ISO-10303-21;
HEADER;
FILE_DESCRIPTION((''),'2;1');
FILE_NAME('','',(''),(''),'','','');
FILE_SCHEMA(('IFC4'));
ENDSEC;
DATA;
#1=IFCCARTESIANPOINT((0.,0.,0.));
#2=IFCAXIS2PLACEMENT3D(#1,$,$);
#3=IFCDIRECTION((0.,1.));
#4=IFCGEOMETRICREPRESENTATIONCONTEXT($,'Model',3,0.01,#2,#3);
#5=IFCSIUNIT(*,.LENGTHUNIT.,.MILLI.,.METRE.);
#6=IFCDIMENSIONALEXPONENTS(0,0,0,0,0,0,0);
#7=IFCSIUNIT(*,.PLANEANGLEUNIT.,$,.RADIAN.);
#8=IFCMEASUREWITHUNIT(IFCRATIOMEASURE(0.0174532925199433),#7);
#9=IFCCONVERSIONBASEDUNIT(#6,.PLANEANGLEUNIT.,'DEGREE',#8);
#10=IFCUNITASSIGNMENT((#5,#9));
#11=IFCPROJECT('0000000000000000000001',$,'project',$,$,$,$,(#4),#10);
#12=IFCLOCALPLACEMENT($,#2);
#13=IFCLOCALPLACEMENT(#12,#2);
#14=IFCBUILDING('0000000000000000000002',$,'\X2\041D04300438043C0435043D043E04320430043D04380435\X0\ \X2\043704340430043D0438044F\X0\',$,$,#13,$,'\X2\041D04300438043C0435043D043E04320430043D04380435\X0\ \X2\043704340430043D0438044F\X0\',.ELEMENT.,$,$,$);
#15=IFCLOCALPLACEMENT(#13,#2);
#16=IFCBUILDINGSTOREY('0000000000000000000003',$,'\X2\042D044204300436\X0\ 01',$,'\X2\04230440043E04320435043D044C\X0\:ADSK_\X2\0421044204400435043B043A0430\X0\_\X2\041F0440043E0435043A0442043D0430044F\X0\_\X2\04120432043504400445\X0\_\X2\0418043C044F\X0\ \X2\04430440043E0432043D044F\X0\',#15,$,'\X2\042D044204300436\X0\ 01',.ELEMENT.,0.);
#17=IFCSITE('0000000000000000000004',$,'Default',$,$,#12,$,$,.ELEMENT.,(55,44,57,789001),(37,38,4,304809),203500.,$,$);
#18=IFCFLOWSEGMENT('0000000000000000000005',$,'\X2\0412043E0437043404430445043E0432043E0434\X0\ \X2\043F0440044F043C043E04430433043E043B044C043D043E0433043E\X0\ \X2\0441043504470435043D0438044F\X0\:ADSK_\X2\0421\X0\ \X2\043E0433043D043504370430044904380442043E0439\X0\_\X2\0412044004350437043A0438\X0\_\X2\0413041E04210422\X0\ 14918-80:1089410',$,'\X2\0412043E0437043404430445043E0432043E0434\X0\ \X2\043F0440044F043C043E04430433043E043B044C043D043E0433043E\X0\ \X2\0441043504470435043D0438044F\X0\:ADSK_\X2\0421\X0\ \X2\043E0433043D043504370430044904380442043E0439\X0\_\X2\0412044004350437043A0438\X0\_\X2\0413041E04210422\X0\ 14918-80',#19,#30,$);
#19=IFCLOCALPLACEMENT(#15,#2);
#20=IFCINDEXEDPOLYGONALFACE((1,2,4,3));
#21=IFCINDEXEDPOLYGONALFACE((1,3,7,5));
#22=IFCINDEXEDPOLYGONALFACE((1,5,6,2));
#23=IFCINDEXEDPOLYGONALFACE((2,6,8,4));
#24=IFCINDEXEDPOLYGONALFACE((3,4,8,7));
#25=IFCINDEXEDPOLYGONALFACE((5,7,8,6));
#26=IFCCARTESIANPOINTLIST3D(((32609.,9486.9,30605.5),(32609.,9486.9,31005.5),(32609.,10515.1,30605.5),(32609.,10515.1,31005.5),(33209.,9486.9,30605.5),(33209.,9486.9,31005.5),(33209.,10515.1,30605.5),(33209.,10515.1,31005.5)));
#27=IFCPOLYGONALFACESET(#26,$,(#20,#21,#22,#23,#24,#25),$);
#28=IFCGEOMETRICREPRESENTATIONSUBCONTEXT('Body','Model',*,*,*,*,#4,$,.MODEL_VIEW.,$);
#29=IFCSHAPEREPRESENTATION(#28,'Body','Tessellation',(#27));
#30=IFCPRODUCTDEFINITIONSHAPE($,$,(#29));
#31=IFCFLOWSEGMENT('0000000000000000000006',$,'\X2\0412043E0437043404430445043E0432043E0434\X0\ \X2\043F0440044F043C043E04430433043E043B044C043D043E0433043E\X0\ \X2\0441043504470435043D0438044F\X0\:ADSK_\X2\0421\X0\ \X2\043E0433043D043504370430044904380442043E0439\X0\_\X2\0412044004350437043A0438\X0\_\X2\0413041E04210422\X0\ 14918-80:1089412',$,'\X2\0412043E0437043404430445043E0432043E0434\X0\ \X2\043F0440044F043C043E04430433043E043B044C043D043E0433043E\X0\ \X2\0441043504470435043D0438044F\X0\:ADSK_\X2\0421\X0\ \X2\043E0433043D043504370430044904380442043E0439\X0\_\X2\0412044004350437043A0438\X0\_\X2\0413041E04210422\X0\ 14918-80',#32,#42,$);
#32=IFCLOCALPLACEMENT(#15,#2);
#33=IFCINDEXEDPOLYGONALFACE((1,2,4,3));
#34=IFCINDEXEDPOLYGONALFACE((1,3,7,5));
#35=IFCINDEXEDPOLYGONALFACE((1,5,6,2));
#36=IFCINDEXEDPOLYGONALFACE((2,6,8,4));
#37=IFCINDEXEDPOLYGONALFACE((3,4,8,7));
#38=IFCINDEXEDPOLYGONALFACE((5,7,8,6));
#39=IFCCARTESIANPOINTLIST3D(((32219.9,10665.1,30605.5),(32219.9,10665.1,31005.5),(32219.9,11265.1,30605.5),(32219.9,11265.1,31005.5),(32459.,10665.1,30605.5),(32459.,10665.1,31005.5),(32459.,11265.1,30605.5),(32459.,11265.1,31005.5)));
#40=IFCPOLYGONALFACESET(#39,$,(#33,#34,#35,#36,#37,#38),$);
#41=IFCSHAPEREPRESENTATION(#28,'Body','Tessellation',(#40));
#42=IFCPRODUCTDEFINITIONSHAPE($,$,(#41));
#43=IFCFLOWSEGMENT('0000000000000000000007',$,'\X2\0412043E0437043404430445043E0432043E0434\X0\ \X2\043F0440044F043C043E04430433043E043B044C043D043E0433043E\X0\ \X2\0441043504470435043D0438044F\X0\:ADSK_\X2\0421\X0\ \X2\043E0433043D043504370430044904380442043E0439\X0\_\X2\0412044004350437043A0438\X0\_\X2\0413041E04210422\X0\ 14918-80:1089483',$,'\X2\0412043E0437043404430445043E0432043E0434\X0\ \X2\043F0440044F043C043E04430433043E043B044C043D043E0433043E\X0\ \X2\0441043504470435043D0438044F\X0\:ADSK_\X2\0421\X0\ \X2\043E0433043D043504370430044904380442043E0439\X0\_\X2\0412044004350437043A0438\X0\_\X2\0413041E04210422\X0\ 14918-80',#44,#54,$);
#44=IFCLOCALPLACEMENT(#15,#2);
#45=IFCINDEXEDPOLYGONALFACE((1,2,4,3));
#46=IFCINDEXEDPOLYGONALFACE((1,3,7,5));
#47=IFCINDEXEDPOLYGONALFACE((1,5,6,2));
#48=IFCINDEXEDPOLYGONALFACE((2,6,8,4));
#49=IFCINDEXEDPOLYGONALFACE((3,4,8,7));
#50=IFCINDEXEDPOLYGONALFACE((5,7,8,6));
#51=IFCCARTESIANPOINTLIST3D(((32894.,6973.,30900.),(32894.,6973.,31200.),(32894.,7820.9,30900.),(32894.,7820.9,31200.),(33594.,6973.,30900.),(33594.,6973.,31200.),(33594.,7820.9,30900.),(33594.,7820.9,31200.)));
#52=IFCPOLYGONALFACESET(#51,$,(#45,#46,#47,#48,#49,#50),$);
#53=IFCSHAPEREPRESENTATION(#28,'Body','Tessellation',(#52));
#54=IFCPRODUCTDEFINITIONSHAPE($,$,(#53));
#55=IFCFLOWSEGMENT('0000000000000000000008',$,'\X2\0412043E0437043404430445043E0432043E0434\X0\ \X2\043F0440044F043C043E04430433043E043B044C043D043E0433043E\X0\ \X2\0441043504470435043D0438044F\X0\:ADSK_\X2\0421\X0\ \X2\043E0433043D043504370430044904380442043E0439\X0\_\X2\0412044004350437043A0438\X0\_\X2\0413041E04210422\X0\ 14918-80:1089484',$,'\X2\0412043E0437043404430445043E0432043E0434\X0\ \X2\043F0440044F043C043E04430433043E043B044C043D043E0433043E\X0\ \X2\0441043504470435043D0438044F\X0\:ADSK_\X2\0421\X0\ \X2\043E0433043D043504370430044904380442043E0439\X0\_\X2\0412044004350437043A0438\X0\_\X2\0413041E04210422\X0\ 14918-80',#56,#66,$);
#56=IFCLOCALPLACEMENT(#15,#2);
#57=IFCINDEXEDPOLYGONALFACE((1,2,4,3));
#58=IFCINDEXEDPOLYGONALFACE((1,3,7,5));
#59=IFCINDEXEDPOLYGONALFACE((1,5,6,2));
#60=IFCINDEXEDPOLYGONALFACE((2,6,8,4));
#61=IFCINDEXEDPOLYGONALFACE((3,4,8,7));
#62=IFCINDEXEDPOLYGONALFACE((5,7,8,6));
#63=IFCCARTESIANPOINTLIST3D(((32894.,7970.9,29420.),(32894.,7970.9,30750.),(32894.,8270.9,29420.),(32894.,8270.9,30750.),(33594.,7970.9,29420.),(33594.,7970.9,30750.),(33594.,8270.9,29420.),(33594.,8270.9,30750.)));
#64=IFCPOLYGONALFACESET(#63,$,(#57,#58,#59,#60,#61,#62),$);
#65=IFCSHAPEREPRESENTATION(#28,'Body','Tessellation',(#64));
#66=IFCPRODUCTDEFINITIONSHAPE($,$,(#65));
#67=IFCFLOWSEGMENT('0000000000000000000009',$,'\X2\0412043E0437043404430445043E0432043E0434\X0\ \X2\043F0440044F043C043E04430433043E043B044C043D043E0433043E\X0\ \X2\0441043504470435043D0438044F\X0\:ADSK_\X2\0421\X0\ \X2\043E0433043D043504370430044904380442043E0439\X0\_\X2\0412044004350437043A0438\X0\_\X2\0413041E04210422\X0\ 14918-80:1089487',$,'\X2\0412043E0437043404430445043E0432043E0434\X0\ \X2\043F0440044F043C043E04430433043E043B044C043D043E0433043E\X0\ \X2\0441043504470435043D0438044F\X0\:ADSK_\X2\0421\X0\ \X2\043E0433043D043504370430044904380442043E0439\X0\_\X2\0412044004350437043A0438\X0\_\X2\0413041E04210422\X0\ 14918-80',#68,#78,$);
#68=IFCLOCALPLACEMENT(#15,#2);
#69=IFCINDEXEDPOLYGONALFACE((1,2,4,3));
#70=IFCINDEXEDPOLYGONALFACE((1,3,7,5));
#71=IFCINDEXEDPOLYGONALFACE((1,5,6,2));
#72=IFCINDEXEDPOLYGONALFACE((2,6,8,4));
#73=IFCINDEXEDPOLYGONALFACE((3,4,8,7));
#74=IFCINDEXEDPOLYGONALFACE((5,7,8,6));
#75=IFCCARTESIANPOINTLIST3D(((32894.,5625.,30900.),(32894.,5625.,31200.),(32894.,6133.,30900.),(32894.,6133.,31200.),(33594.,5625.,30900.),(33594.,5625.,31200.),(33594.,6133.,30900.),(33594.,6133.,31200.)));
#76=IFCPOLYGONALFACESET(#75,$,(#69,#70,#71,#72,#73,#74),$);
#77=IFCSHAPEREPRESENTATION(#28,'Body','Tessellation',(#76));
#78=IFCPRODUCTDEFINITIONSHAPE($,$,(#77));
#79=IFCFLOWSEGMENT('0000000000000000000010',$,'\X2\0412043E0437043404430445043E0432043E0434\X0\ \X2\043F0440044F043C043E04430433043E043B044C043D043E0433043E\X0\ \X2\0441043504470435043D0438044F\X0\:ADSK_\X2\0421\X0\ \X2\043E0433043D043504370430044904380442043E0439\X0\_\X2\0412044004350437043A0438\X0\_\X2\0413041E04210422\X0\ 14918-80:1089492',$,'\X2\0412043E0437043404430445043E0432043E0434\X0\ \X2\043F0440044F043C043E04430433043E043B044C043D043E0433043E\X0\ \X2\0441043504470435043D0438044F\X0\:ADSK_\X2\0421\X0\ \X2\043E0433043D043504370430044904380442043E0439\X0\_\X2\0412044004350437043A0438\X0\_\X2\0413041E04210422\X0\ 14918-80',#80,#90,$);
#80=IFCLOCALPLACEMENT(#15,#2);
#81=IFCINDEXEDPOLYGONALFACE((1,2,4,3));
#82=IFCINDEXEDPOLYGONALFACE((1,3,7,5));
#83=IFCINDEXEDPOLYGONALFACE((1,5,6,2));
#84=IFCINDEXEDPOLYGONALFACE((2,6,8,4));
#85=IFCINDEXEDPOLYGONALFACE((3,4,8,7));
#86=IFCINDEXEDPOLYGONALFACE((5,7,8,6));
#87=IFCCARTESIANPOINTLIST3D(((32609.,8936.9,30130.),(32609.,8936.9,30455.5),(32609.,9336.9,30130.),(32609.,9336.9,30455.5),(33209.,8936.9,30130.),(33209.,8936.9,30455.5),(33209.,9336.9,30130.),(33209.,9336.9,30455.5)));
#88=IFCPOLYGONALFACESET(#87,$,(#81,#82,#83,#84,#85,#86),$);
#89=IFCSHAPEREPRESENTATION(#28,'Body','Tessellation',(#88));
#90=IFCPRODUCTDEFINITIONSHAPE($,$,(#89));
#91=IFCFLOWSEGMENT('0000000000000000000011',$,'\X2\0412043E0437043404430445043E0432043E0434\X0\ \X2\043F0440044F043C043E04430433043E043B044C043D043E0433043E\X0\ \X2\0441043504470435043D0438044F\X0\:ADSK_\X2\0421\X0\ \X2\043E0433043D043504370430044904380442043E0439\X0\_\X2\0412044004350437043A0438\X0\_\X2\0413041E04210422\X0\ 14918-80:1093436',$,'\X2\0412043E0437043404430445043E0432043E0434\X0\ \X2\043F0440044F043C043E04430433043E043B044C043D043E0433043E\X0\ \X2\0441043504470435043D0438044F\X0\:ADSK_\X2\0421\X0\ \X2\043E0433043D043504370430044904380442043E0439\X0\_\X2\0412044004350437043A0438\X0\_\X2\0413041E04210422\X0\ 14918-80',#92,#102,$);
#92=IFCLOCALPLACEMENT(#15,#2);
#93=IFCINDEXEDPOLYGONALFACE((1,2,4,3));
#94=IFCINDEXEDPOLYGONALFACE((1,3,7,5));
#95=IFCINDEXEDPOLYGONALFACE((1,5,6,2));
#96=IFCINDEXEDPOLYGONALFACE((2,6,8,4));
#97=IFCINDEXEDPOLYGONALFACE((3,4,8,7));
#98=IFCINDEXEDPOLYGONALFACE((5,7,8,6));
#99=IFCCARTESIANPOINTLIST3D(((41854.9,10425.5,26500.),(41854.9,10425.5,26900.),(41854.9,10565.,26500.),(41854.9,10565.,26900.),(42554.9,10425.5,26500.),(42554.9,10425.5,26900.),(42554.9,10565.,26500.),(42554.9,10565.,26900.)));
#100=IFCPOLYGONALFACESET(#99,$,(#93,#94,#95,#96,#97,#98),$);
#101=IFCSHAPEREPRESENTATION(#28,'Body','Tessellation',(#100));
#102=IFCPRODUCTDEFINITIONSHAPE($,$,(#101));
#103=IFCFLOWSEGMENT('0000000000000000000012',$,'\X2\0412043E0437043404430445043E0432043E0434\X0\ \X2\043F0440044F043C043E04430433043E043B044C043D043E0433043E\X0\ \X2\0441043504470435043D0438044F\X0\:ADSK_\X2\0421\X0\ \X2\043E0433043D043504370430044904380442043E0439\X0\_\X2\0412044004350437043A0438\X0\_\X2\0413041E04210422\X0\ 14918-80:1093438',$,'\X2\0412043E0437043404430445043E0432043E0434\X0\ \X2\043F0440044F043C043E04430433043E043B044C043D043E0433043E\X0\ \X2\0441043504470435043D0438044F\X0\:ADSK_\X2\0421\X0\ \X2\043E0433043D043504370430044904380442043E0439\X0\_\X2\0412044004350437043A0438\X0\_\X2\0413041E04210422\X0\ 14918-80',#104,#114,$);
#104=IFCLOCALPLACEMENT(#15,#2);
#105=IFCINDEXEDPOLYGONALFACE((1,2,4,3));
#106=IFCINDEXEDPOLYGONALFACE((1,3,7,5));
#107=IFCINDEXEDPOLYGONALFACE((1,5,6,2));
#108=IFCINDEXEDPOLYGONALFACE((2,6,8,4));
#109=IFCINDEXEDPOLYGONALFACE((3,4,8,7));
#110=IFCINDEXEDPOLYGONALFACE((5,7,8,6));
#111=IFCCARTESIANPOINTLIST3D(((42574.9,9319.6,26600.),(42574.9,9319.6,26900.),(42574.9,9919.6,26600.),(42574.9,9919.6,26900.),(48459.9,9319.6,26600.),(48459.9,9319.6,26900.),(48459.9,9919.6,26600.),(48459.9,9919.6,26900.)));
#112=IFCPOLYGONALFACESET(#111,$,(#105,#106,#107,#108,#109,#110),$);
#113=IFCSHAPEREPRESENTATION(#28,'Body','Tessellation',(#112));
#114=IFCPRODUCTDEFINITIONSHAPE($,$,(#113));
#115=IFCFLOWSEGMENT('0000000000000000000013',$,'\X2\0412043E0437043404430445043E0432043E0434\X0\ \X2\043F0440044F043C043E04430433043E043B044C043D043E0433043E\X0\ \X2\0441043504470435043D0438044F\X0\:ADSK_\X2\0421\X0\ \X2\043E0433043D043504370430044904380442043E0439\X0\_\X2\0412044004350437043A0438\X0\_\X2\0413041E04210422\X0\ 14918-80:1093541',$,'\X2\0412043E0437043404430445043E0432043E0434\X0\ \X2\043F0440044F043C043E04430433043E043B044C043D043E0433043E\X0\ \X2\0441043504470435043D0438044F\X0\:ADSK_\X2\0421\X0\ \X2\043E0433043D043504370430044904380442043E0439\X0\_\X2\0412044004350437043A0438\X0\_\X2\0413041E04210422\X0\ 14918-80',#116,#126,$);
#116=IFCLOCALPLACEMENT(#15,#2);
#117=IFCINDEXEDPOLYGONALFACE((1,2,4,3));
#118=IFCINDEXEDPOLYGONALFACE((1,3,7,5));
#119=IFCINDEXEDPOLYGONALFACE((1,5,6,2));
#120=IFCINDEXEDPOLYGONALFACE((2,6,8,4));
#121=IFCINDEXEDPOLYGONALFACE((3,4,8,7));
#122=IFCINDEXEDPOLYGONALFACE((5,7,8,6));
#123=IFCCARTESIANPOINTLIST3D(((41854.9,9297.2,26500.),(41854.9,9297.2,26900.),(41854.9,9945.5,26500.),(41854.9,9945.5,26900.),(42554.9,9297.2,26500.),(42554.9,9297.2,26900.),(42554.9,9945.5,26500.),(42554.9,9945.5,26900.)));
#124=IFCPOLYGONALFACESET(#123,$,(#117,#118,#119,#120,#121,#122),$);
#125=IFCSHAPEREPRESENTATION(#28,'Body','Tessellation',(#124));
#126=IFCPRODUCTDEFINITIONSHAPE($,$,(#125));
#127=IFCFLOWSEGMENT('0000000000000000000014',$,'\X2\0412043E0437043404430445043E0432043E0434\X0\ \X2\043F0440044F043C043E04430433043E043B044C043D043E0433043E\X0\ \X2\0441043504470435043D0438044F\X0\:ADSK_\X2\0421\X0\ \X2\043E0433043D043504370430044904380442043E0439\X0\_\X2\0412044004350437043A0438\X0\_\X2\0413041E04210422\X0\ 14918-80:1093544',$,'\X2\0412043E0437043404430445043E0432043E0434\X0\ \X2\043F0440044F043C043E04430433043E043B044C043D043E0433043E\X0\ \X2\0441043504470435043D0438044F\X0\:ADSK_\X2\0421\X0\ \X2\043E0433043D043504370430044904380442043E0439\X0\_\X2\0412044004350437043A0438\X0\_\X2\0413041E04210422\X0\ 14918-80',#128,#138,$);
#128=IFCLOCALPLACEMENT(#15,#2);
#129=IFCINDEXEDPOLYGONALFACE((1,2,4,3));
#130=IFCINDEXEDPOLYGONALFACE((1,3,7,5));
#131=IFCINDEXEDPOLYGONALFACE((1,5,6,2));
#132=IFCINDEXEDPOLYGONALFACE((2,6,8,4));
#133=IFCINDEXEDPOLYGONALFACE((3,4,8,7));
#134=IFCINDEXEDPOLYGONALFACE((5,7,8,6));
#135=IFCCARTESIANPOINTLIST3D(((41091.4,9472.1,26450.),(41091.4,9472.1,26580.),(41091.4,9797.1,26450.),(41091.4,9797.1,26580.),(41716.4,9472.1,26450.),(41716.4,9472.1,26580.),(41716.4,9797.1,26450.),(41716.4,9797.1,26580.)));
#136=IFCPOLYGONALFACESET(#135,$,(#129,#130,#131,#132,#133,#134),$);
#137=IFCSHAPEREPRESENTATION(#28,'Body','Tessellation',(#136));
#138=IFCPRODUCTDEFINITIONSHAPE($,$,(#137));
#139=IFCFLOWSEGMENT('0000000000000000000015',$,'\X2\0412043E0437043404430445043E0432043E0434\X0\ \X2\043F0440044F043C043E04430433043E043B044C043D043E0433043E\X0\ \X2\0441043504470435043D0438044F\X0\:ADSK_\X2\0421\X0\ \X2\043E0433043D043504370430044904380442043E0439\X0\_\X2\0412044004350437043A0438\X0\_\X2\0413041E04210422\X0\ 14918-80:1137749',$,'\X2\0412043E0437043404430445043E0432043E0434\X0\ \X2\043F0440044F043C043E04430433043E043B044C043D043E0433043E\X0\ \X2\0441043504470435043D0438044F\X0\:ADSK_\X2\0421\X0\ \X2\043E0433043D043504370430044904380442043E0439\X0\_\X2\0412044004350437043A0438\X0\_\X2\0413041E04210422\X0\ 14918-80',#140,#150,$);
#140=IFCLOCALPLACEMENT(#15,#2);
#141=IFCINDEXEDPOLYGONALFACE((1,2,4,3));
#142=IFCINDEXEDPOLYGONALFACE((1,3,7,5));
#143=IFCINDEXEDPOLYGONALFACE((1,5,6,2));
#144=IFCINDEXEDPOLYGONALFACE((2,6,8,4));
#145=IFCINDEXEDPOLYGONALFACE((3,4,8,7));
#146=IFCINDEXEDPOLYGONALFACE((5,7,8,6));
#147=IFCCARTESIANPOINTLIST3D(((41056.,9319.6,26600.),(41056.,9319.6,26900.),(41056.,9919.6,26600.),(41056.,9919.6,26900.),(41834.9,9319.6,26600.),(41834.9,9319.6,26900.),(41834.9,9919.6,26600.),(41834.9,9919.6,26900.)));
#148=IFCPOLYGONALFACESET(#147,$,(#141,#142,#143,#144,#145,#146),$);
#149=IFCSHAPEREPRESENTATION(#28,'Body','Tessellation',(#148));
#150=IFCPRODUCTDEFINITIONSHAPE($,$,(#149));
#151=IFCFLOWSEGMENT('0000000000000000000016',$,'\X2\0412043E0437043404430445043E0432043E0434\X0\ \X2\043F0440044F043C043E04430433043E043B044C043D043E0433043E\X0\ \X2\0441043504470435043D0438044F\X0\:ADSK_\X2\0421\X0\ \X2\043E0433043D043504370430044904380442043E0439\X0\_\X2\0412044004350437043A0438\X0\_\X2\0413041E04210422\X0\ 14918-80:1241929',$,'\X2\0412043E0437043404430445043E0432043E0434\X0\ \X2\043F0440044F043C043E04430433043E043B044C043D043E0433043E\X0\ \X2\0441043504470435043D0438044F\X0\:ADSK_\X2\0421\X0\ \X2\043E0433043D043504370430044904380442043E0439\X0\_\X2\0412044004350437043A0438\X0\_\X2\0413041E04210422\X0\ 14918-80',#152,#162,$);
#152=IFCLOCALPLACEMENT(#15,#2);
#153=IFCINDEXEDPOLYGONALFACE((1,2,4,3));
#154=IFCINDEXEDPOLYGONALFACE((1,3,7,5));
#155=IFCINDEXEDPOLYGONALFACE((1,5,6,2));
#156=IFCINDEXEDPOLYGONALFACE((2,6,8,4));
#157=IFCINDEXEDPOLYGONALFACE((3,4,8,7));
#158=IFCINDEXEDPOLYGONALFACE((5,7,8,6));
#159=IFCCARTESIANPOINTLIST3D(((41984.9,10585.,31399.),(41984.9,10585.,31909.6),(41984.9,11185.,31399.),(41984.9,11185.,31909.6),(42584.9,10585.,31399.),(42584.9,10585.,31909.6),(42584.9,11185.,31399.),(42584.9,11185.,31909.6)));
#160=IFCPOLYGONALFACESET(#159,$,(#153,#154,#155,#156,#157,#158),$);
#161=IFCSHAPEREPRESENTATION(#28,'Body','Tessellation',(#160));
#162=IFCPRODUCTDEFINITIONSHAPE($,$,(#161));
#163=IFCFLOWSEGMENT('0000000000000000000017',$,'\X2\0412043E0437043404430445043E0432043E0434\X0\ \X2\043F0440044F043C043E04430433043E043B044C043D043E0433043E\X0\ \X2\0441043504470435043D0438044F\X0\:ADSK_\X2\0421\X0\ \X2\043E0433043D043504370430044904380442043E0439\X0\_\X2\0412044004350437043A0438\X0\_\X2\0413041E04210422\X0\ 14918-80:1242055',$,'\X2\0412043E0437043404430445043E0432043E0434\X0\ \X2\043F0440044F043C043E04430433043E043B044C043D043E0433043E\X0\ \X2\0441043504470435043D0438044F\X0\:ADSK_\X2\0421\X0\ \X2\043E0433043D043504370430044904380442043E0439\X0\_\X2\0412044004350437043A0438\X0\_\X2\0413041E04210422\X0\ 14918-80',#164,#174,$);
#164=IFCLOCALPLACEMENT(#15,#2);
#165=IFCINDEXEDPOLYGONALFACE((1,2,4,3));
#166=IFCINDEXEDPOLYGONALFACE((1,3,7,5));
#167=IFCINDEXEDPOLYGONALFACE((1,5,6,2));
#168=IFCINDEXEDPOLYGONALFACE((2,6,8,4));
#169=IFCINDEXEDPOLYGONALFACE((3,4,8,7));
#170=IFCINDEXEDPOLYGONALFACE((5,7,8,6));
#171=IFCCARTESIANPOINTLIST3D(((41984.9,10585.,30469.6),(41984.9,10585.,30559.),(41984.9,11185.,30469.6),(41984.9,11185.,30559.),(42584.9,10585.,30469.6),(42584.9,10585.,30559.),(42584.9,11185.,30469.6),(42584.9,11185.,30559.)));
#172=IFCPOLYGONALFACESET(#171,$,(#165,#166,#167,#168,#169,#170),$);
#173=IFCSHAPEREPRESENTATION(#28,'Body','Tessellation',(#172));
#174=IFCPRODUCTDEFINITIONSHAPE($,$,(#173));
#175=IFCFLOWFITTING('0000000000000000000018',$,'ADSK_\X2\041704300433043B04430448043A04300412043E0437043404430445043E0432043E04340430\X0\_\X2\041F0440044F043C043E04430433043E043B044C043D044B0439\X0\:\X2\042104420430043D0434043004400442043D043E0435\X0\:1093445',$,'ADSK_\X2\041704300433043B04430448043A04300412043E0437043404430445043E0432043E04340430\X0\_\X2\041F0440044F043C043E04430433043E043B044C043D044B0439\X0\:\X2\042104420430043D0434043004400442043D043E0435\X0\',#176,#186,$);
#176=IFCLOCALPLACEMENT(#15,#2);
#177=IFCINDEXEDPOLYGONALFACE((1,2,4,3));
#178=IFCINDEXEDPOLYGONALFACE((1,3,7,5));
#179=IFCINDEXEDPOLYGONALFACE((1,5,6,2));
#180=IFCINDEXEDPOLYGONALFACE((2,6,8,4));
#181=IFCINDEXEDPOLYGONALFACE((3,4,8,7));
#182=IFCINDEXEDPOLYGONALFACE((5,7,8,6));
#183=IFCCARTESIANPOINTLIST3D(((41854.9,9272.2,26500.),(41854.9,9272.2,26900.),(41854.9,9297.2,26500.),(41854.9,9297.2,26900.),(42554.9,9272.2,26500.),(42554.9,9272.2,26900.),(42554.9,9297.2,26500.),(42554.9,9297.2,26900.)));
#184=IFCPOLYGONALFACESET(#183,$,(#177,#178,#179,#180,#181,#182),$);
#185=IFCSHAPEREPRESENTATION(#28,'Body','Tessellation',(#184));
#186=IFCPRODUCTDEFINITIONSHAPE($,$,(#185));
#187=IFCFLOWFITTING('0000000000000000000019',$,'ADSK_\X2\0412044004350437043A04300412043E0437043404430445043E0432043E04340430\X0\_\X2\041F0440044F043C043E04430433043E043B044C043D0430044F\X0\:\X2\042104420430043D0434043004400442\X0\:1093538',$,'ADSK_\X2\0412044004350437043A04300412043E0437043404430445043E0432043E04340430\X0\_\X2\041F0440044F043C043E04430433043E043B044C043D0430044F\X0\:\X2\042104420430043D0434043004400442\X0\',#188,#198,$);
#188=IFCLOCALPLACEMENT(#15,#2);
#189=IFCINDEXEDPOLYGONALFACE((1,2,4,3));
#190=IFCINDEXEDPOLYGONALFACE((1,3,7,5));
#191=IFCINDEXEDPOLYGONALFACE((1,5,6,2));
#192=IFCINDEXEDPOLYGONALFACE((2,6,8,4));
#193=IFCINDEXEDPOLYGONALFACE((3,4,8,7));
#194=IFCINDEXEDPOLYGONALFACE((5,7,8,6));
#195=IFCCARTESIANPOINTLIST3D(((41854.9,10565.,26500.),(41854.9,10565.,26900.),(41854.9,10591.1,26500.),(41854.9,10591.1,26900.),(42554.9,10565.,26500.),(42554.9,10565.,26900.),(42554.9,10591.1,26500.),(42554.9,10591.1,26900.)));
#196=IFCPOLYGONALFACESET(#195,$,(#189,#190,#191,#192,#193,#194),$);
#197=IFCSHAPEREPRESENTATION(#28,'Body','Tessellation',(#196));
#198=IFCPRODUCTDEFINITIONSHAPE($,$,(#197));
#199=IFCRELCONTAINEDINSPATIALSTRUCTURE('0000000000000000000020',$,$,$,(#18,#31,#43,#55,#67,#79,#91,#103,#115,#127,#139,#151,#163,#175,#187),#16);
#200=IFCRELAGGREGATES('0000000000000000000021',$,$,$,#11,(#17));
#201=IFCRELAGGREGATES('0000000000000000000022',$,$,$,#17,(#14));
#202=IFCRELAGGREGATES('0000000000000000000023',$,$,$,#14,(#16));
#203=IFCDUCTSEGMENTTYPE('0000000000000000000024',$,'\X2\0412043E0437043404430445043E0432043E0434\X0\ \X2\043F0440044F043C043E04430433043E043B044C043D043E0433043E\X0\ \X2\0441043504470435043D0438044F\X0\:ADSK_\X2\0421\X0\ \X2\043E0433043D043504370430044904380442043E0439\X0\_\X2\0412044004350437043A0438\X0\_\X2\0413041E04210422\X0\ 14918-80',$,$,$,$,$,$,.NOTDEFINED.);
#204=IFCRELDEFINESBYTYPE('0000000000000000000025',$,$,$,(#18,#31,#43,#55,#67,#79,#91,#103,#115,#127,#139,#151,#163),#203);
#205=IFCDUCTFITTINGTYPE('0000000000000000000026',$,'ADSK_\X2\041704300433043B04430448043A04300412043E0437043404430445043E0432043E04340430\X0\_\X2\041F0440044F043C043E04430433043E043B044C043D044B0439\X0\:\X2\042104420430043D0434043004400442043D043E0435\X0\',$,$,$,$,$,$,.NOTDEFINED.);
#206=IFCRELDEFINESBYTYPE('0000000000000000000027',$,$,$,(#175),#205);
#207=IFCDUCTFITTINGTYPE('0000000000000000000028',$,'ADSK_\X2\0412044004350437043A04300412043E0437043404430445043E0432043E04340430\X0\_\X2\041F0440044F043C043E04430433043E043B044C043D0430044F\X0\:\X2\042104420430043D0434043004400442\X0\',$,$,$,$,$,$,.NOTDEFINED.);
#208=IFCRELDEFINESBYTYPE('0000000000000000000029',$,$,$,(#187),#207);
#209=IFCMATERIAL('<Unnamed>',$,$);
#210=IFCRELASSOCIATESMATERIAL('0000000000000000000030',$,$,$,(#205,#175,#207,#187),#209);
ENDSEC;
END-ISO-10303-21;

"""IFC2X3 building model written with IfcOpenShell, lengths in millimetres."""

from ifc_helpers import new_model, entity, si_unit, converted_unit, direction, frame, origin, origin_2d_with_axis, place, context, subcontext, project, spatial, rectangle, extrude, source, transform, mapped, material, type_object, type_shapes, element, save


model = new_model("IFC2X3")

# Units and contexts
model_context = context("Model", 3, precision=0.01, world=origin(), true_north=direction((0.0, 1.0)))
body_context = subcontext(model_context, "Body", "Model", "MODEL_VIEW")
ifc_project = project(units=[si_unit("LENGTHUNIT", "METRE", prefix="MILLI"), converted_unit("PLANEANGLEUNIT", "DEGREE", entity("IfcRatioMeasure", 0.0174532925199433), si_unit("PLANEANGLEUNIT", "RADIAN"), dimensions=[0, 0, 0, 0, 0, 0, 0])], contexts=[model_context])

# Site, building, storey
site_placement = place(None, origin())
site = spatial("IfcSite", under=ifc_project, at=site_placement, Name="Default", CompositionType="ELEMENT", RefLatitude=(55, 44, 57, 789001), RefLongitude=(37, 38, 4, 304809), RefElevation=203500.0)
building_placement = place(site_placement, origin())
building = spatial("IfcBuilding", under=site, at=building_placement, Name="Наименование здания", LongName="Наименование здания", CompositionType="ELEMENT")
storey_placement = place(building_placement, origin())
storey = spatial("IfcBuildingStorey", under=building, at=storey_placement, Name="Этаж 01", ObjectType="Уровень:ADSK_Стрелка_Проектная_Вверх_Имя уровня", LongName="Этаж 01", CompositionType="ELEMENT", Elevation=0.0)

# Flow segments
duct_segment_type = type_object("IfcDuctSegmentType", Name="Воздуховод прямоугольного сечения:ADSK_С огнезащитой_Врезки_ГОСТ 14918-80", PredefinedType="NOTDEFINED")
flow_segment_1_placement = place(storey_placement, frame((32609.0, 9486.9, 30605.5)))
element("IfcFlowSegment", 1, at=flow_segment_1_placement, inside=storey, type_object=duct_segment_type, Name="Воздуховод прямоугольного сечения:ADSK_С огнезащитой_Врезки_ГОСТ 14918-80:1089410", ObjectType="Воздуховод прямоугольного сечения:ADSK_С огнезащитой_Врезки_ГОСТ 14918-80", context=body_context, shape_type="SweptSolid", body=[
    extrude(rectangle(XDim=1028.2, YDim=600.0, at=origin_2d_with_axis()), frame((300.0, 514.1, 0.0), z_axis=(0.0, 0.0, 1.0), x_axis=(0.0, 1.0, 0.0)), (0.0, 0.0, 1.0), 400.0),
])
flow_segment_2_placement = place(storey_placement, frame((32219.9, 10665.1, 30605.5)))
element("IfcFlowSegment", 2, at=flow_segment_2_placement, inside=storey, type_object=duct_segment_type, Name="Воздуховод прямоугольного сечения:ADSK_С огнезащитой_Врезки_ГОСТ 14918-80:1089412", ObjectType="Воздуховод прямоугольного сечения:ADSK_С огнезащитой_Врезки_ГОСТ 14918-80", context=body_context, shape_type="SweptSolid", body=[
    extrude(rectangle(XDim=239.1, YDim=600.0, at=origin_2d_with_axis()), frame((119.6, 300.0, 0.0)), (0.0, 0.0, 1.0), 400.0),
])
flow_segment_3_placement = place(storey_placement, frame((32894.0, 6973.0, 30900.0)))
element("IfcFlowSegment", 3, at=flow_segment_3_placement, inside=storey, type_object=duct_segment_type, Name="Воздуховод прямоугольного сечения:ADSK_С огнезащитой_Врезки_ГОСТ 14918-80:1089483", ObjectType="Воздуховод прямоугольного сечения:ADSK_С огнезащитой_Врезки_ГОСТ 14918-80", context=body_context, shape_type="SweptSolid", body=[
    extrude(rectangle(XDim=848.0, YDim=700.0, at=origin_2d_with_axis()), frame((350.0, 424.0, 0.0), z_axis=(0.0, 0.0, 1.0), x_axis=(0.0, -1.0, 0.0)), (0.0, 0.0, 1.0), 300.0),
])
flow_segment_4_placement = place(storey_placement, frame((32894.0, 7970.9, 29420.0)))
element("IfcFlowSegment", 4, at=flow_segment_4_placement, inside=storey, type_object=duct_segment_type, Name="Воздуховод прямоугольного сечения:ADSK_С огнезащитой_Врезки_ГОСТ 14918-80:1089484", ObjectType="Воздуховод прямоугольного сечения:ADSK_С огнезащитой_Врезки_ГОСТ 14918-80", context=body_context, shape_type="SweptSolid", body=[
    extrude(rectangle(XDim=300.0, YDim=700.0, at=origin_2d_with_axis()), frame((350.0, 150.0, 0.0), z_axis=(0.0, 0.0, 1.0), x_axis=(0.0, 1.0, 0.0)), (0.0, 0.0, 1.0), 1330.0),
])
flow_segment_5_placement = place(storey_placement, frame((32894.0, 5625.0, 30900.0)))
element("IfcFlowSegment", 5, at=flow_segment_5_placement, inside=storey, type_object=duct_segment_type, Name="Воздуховод прямоугольного сечения:ADSK_С огнезащитой_Врезки_ГОСТ 14918-80:1089487", ObjectType="Воздуховод прямоугольного сечения:ADSK_С огнезащитой_Врезки_ГОСТ 14918-80", context=body_context, shape_type="SweptSolid", body=[
    extrude(rectangle(XDim=508.0, YDim=700.0, at=origin_2d_with_axis()), frame((350.0, 254.0, 0.0), z_axis=(0.0, 0.0, 1.0), x_axis=(0.0, -1.0, 0.0)), (0.0, 0.0, 1.0), 300.0),
])
flow_segment_6_placement = place(storey_placement, frame((32609.0, 8936.9, 30130.0)))
element("IfcFlowSegment", 6, at=flow_segment_6_placement, inside=storey, type_object=duct_segment_type, Name="Воздуховод прямоугольного сечения:ADSK_С огнезащитой_Врезки_ГОСТ 14918-80:1089492", ObjectType="Воздуховод прямоугольного сечения:ADSK_С огнезащитой_Врезки_ГОСТ 14918-80", context=body_context, shape_type="SweptSolid", body=[
    extrude(rectangle(XDim=600.0, YDim=400.0, at=origin_2d_with_axis()), frame((300.0, 200.0, 0.0)), (0.0, 0.0, 1.0), 325.5),
])
flow_segment_7_placement = place(storey_placement, frame((41854.9, 10425.5, 26500.0)))
element("IfcFlowSegment", 7, at=flow_segment_7_placement, inside=storey, type_object=duct_segment_type, Name="Воздуховод прямоугольного сечения:ADSK_С огнезащитой_Врезки_ГОСТ 14918-80:1093436", ObjectType="Воздуховод прямоугольного сечения:ADSK_С огнезащитой_Врезки_ГОСТ 14918-80", context=body_context, shape_type="SweptSolid", body=[
    extrude(rectangle(XDim=139.5, YDim=700.0, at=origin_2d_with_axis()), frame((350.0, 69.7, 0.0), z_axis=(0.0, 0.0, 1.0), x_axis=(0.0, 1.0, 0.0)), (0.0, 0.0, 1.0), 400.0),
])
flow_segment_8_placement = place(storey_placement, frame((42574.9, 9319.6, 26600.0)))
element("IfcFlowSegment", 8, at=flow_segment_8_placement, inside=storey, type_object=duct_segment_type, Name="Воздуховод прямоугольного сечения:ADSK_С огнезащитой_Врезки_ГОСТ 14918-80:1093438", ObjectType="Воздуховод прямоугольного сечения:ADSK_С огнезащитой_Врезки_ГОСТ 14918-80", context=body_context, shape_type="SweptSolid", body=[
    extrude(rectangle(XDim=5885.0, YDim=600.0, at=origin_2d_with_axis()), frame((2942.5, 300.0, 0.0), z_axis=(0.0, 0.0, 1.0), x_axis=(-1.0, 0.0, 0.0)), (0.0, 0.0, 1.0), 300.0),
])
flow_segment_9_placement = place(storey_placement, frame((41854.9, 9297.2, 26500.0)))
element("IfcFlowSegment", 9, at=flow_segment_9_placement, inside=storey, type_object=duct_segment_type, Name="Воздуховод прямоугольного сечения:ADSK_С огнезащитой_Врезки_ГОСТ 14918-80:1093541", ObjectType="Воздуховод прямоугольного сечения:ADSK_С огнезащитой_Врезки_ГОСТ 14918-80", context=body_context, shape_type="SweptSolid", body=[
    extrude(rectangle(XDim=648.3, YDim=700.0, at=origin_2d_with_axis()), frame((350.0, 324.1, 0.0), z_axis=(0.0, 0.0, 1.0), x_axis=(0.0, 1.0, 0.0)), (0.0, 0.0, 1.0), 400.0),
])
flow_segment_10_placement = place(storey_placement, frame((41091.4, 9472.1, 26450.0)))
element("IfcFlowSegment", 10, at=flow_segment_10_placement, inside=storey, type_object=duct_segment_type, Name="Воздуховод прямоугольного сечения:ADSK_С огнезащитой_Врезки_ГОСТ 14918-80:1093544", ObjectType="Воздуховод прямоугольного сечения:ADSK_С огнезащитой_Врезки_ГОСТ 14918-80", context=body_context, shape_type="SweptSolid", body=[
    extrude(rectangle(XDim=625.0, YDim=325.0, at=origin_2d_with_axis()), frame((312.5, 162.5, 0.0)), (0.0, 0.0, 1.0), 130.0),
])
flow_segment_11_placement = place(storey_placement, frame((41056.0, 9319.6, 26600.0)))
element("IfcFlowSegment", 11, at=flow_segment_11_placement, inside=storey, type_object=duct_segment_type, Name="Воздуховод прямоугольного сечения:ADSK_С огнезащитой_Врезки_ГОСТ 14918-80:1137749", ObjectType="Воздуховод прямоугольного сечения:ADSK_С огнезащитой_Врезки_ГОСТ 14918-80", context=body_context, shape_type="SweptSolid", body=[
    extrude(rectangle(XDim=778.9, YDim=600.0, at=origin_2d_with_axis()), frame((389.4, 300.0, 0.0)), (0.0, 0.0, 1.0), 300.0),
])
flow_segment_12_placement = place(storey_placement, frame((41984.9, 10585.0, 31399.0)))
element("IfcFlowSegment", 12, at=flow_segment_12_placement, inside=storey, type_object=duct_segment_type, Name="Воздуховод прямоугольного сечения:ADSK_С огнезащитой_Врезки_ГОСТ 14918-80:1241929", ObjectType="Воздуховод прямоугольного сечения:ADSK_С огнезащитой_Врезки_ГОСТ 14918-80", context=body_context, shape_type="SweptSolid", body=[
    extrude(rectangle(XDim=600.0, YDim=600.0, at=origin_2d_with_axis()), frame((300.0, 300.0, 0.0)), (0.0, 0.0, 1.0), 510.6),
])
flow_segment_13_placement = place(storey_placement, frame((41984.9, 10585.0, 30469.6)))
element("IfcFlowSegment", 13, at=flow_segment_13_placement, inside=storey, type_object=duct_segment_type, Name="Воздуховод прямоугольного сечения:ADSK_С огнезащитой_Врезки_ГОСТ 14918-80:1242055", ObjectType="Воздуховод прямоугольного сечения:ADSK_С огнезащитой_Врезки_ГОСТ 14918-80", context=body_context, shape_type="SweptSolid", body=[
    extrude(rectangle(XDim=600.0, YDim=600.0, at=origin_2d_with_axis()), frame((300.0, 300.0, 0.0)), (0.0, 0.0, 1.0), 89.4),
])

# Flow fittings
ifc_material_1 = material(Name="<Unnamed>")
duct_fitting_type_1 = type_object("IfcDuctFittingType", Name="ADSK_ЗаглушкаВоздуховода_Прямоугольный:Стандартное", PredefinedType="NOTDEFINED", material=ifc_material_1)
shared_shape_1 = source(origin(), body_context, "Body", "SweptSolid", [
    extrude(rectangle(XDim=25.0, YDim=700.0, at=origin_2d_with_axis()), frame((12.5, 0.0, -200.0)), (0.0, 0.0, 1.0), 400.0),
])
type_shapes(duct_fitting_type_1, [shared_shape_1])
flow_fitting_1_placement = place(storey_placement, frame((42204.9, 9297.2, 26700.0), z_axis=(0.0, 0.0, 1.0), x_axis=(0.0, -1.0, 0.0)))
element("IfcFlowFitting", 14, at=flow_fitting_1_placement, inside=storey, type_object=duct_fitting_type_1, material=ifc_material_1, Name="ADSK_ЗаглушкаВоздуховода_Прямоугольный:Стандартное:1093445", ObjectType="ADSK_ЗаглушкаВоздуховода_Прямоугольный:Стандартное", context=body_context, shape_type="MappedRepresentation", body=[
    mapped(shared_shape_1, transform((0.0, 0.0, 0.0), scale=1.0)),
])
duct_fitting_type_2 = type_object("IfcDuctFittingType", Name="ADSK_ВрезкаВоздуховода_Прямоугольная:Стандарт", PredefinedType="NOTDEFINED", material=ifc_material_1)
shared_shape_2 = source(origin(), body_context, "Body", "SweptSolid", [
    extrude(rectangle(XDim=26.1, YDim=400.0, at=origin_2d_with_axis()), frame((7.0, 0.0, -350.0)), (0.0, 0.0, 1.0), 700.0),
])
type_shapes(duct_fitting_type_2, [shared_shape_2])
flow_fitting_2_placement = place(storey_placement, frame((42204.9, 10585.0, 26700.0), z_axis=(-1.0, 0.0, 0.0), x_axis=(0.0, -1.0, 0.0)))
element("IfcFlowFitting", 15, at=flow_fitting_2_placement, inside=storey, type_object=duct_fitting_type_2, material=ifc_material_1, Name="ADSK_ВрезкаВоздуховода_Прямоугольная:Стандарт:1093538", ObjectType="ADSK_ВрезкаВоздуховода_Прямоугольная:Стандарт", context=body_context, shape_type="MappedRepresentation", body=[
    mapped(shared_shape_2, transform((0.0, 0.0, 0.0), scale=1.0)),
])

save(model, "model.ifc")
